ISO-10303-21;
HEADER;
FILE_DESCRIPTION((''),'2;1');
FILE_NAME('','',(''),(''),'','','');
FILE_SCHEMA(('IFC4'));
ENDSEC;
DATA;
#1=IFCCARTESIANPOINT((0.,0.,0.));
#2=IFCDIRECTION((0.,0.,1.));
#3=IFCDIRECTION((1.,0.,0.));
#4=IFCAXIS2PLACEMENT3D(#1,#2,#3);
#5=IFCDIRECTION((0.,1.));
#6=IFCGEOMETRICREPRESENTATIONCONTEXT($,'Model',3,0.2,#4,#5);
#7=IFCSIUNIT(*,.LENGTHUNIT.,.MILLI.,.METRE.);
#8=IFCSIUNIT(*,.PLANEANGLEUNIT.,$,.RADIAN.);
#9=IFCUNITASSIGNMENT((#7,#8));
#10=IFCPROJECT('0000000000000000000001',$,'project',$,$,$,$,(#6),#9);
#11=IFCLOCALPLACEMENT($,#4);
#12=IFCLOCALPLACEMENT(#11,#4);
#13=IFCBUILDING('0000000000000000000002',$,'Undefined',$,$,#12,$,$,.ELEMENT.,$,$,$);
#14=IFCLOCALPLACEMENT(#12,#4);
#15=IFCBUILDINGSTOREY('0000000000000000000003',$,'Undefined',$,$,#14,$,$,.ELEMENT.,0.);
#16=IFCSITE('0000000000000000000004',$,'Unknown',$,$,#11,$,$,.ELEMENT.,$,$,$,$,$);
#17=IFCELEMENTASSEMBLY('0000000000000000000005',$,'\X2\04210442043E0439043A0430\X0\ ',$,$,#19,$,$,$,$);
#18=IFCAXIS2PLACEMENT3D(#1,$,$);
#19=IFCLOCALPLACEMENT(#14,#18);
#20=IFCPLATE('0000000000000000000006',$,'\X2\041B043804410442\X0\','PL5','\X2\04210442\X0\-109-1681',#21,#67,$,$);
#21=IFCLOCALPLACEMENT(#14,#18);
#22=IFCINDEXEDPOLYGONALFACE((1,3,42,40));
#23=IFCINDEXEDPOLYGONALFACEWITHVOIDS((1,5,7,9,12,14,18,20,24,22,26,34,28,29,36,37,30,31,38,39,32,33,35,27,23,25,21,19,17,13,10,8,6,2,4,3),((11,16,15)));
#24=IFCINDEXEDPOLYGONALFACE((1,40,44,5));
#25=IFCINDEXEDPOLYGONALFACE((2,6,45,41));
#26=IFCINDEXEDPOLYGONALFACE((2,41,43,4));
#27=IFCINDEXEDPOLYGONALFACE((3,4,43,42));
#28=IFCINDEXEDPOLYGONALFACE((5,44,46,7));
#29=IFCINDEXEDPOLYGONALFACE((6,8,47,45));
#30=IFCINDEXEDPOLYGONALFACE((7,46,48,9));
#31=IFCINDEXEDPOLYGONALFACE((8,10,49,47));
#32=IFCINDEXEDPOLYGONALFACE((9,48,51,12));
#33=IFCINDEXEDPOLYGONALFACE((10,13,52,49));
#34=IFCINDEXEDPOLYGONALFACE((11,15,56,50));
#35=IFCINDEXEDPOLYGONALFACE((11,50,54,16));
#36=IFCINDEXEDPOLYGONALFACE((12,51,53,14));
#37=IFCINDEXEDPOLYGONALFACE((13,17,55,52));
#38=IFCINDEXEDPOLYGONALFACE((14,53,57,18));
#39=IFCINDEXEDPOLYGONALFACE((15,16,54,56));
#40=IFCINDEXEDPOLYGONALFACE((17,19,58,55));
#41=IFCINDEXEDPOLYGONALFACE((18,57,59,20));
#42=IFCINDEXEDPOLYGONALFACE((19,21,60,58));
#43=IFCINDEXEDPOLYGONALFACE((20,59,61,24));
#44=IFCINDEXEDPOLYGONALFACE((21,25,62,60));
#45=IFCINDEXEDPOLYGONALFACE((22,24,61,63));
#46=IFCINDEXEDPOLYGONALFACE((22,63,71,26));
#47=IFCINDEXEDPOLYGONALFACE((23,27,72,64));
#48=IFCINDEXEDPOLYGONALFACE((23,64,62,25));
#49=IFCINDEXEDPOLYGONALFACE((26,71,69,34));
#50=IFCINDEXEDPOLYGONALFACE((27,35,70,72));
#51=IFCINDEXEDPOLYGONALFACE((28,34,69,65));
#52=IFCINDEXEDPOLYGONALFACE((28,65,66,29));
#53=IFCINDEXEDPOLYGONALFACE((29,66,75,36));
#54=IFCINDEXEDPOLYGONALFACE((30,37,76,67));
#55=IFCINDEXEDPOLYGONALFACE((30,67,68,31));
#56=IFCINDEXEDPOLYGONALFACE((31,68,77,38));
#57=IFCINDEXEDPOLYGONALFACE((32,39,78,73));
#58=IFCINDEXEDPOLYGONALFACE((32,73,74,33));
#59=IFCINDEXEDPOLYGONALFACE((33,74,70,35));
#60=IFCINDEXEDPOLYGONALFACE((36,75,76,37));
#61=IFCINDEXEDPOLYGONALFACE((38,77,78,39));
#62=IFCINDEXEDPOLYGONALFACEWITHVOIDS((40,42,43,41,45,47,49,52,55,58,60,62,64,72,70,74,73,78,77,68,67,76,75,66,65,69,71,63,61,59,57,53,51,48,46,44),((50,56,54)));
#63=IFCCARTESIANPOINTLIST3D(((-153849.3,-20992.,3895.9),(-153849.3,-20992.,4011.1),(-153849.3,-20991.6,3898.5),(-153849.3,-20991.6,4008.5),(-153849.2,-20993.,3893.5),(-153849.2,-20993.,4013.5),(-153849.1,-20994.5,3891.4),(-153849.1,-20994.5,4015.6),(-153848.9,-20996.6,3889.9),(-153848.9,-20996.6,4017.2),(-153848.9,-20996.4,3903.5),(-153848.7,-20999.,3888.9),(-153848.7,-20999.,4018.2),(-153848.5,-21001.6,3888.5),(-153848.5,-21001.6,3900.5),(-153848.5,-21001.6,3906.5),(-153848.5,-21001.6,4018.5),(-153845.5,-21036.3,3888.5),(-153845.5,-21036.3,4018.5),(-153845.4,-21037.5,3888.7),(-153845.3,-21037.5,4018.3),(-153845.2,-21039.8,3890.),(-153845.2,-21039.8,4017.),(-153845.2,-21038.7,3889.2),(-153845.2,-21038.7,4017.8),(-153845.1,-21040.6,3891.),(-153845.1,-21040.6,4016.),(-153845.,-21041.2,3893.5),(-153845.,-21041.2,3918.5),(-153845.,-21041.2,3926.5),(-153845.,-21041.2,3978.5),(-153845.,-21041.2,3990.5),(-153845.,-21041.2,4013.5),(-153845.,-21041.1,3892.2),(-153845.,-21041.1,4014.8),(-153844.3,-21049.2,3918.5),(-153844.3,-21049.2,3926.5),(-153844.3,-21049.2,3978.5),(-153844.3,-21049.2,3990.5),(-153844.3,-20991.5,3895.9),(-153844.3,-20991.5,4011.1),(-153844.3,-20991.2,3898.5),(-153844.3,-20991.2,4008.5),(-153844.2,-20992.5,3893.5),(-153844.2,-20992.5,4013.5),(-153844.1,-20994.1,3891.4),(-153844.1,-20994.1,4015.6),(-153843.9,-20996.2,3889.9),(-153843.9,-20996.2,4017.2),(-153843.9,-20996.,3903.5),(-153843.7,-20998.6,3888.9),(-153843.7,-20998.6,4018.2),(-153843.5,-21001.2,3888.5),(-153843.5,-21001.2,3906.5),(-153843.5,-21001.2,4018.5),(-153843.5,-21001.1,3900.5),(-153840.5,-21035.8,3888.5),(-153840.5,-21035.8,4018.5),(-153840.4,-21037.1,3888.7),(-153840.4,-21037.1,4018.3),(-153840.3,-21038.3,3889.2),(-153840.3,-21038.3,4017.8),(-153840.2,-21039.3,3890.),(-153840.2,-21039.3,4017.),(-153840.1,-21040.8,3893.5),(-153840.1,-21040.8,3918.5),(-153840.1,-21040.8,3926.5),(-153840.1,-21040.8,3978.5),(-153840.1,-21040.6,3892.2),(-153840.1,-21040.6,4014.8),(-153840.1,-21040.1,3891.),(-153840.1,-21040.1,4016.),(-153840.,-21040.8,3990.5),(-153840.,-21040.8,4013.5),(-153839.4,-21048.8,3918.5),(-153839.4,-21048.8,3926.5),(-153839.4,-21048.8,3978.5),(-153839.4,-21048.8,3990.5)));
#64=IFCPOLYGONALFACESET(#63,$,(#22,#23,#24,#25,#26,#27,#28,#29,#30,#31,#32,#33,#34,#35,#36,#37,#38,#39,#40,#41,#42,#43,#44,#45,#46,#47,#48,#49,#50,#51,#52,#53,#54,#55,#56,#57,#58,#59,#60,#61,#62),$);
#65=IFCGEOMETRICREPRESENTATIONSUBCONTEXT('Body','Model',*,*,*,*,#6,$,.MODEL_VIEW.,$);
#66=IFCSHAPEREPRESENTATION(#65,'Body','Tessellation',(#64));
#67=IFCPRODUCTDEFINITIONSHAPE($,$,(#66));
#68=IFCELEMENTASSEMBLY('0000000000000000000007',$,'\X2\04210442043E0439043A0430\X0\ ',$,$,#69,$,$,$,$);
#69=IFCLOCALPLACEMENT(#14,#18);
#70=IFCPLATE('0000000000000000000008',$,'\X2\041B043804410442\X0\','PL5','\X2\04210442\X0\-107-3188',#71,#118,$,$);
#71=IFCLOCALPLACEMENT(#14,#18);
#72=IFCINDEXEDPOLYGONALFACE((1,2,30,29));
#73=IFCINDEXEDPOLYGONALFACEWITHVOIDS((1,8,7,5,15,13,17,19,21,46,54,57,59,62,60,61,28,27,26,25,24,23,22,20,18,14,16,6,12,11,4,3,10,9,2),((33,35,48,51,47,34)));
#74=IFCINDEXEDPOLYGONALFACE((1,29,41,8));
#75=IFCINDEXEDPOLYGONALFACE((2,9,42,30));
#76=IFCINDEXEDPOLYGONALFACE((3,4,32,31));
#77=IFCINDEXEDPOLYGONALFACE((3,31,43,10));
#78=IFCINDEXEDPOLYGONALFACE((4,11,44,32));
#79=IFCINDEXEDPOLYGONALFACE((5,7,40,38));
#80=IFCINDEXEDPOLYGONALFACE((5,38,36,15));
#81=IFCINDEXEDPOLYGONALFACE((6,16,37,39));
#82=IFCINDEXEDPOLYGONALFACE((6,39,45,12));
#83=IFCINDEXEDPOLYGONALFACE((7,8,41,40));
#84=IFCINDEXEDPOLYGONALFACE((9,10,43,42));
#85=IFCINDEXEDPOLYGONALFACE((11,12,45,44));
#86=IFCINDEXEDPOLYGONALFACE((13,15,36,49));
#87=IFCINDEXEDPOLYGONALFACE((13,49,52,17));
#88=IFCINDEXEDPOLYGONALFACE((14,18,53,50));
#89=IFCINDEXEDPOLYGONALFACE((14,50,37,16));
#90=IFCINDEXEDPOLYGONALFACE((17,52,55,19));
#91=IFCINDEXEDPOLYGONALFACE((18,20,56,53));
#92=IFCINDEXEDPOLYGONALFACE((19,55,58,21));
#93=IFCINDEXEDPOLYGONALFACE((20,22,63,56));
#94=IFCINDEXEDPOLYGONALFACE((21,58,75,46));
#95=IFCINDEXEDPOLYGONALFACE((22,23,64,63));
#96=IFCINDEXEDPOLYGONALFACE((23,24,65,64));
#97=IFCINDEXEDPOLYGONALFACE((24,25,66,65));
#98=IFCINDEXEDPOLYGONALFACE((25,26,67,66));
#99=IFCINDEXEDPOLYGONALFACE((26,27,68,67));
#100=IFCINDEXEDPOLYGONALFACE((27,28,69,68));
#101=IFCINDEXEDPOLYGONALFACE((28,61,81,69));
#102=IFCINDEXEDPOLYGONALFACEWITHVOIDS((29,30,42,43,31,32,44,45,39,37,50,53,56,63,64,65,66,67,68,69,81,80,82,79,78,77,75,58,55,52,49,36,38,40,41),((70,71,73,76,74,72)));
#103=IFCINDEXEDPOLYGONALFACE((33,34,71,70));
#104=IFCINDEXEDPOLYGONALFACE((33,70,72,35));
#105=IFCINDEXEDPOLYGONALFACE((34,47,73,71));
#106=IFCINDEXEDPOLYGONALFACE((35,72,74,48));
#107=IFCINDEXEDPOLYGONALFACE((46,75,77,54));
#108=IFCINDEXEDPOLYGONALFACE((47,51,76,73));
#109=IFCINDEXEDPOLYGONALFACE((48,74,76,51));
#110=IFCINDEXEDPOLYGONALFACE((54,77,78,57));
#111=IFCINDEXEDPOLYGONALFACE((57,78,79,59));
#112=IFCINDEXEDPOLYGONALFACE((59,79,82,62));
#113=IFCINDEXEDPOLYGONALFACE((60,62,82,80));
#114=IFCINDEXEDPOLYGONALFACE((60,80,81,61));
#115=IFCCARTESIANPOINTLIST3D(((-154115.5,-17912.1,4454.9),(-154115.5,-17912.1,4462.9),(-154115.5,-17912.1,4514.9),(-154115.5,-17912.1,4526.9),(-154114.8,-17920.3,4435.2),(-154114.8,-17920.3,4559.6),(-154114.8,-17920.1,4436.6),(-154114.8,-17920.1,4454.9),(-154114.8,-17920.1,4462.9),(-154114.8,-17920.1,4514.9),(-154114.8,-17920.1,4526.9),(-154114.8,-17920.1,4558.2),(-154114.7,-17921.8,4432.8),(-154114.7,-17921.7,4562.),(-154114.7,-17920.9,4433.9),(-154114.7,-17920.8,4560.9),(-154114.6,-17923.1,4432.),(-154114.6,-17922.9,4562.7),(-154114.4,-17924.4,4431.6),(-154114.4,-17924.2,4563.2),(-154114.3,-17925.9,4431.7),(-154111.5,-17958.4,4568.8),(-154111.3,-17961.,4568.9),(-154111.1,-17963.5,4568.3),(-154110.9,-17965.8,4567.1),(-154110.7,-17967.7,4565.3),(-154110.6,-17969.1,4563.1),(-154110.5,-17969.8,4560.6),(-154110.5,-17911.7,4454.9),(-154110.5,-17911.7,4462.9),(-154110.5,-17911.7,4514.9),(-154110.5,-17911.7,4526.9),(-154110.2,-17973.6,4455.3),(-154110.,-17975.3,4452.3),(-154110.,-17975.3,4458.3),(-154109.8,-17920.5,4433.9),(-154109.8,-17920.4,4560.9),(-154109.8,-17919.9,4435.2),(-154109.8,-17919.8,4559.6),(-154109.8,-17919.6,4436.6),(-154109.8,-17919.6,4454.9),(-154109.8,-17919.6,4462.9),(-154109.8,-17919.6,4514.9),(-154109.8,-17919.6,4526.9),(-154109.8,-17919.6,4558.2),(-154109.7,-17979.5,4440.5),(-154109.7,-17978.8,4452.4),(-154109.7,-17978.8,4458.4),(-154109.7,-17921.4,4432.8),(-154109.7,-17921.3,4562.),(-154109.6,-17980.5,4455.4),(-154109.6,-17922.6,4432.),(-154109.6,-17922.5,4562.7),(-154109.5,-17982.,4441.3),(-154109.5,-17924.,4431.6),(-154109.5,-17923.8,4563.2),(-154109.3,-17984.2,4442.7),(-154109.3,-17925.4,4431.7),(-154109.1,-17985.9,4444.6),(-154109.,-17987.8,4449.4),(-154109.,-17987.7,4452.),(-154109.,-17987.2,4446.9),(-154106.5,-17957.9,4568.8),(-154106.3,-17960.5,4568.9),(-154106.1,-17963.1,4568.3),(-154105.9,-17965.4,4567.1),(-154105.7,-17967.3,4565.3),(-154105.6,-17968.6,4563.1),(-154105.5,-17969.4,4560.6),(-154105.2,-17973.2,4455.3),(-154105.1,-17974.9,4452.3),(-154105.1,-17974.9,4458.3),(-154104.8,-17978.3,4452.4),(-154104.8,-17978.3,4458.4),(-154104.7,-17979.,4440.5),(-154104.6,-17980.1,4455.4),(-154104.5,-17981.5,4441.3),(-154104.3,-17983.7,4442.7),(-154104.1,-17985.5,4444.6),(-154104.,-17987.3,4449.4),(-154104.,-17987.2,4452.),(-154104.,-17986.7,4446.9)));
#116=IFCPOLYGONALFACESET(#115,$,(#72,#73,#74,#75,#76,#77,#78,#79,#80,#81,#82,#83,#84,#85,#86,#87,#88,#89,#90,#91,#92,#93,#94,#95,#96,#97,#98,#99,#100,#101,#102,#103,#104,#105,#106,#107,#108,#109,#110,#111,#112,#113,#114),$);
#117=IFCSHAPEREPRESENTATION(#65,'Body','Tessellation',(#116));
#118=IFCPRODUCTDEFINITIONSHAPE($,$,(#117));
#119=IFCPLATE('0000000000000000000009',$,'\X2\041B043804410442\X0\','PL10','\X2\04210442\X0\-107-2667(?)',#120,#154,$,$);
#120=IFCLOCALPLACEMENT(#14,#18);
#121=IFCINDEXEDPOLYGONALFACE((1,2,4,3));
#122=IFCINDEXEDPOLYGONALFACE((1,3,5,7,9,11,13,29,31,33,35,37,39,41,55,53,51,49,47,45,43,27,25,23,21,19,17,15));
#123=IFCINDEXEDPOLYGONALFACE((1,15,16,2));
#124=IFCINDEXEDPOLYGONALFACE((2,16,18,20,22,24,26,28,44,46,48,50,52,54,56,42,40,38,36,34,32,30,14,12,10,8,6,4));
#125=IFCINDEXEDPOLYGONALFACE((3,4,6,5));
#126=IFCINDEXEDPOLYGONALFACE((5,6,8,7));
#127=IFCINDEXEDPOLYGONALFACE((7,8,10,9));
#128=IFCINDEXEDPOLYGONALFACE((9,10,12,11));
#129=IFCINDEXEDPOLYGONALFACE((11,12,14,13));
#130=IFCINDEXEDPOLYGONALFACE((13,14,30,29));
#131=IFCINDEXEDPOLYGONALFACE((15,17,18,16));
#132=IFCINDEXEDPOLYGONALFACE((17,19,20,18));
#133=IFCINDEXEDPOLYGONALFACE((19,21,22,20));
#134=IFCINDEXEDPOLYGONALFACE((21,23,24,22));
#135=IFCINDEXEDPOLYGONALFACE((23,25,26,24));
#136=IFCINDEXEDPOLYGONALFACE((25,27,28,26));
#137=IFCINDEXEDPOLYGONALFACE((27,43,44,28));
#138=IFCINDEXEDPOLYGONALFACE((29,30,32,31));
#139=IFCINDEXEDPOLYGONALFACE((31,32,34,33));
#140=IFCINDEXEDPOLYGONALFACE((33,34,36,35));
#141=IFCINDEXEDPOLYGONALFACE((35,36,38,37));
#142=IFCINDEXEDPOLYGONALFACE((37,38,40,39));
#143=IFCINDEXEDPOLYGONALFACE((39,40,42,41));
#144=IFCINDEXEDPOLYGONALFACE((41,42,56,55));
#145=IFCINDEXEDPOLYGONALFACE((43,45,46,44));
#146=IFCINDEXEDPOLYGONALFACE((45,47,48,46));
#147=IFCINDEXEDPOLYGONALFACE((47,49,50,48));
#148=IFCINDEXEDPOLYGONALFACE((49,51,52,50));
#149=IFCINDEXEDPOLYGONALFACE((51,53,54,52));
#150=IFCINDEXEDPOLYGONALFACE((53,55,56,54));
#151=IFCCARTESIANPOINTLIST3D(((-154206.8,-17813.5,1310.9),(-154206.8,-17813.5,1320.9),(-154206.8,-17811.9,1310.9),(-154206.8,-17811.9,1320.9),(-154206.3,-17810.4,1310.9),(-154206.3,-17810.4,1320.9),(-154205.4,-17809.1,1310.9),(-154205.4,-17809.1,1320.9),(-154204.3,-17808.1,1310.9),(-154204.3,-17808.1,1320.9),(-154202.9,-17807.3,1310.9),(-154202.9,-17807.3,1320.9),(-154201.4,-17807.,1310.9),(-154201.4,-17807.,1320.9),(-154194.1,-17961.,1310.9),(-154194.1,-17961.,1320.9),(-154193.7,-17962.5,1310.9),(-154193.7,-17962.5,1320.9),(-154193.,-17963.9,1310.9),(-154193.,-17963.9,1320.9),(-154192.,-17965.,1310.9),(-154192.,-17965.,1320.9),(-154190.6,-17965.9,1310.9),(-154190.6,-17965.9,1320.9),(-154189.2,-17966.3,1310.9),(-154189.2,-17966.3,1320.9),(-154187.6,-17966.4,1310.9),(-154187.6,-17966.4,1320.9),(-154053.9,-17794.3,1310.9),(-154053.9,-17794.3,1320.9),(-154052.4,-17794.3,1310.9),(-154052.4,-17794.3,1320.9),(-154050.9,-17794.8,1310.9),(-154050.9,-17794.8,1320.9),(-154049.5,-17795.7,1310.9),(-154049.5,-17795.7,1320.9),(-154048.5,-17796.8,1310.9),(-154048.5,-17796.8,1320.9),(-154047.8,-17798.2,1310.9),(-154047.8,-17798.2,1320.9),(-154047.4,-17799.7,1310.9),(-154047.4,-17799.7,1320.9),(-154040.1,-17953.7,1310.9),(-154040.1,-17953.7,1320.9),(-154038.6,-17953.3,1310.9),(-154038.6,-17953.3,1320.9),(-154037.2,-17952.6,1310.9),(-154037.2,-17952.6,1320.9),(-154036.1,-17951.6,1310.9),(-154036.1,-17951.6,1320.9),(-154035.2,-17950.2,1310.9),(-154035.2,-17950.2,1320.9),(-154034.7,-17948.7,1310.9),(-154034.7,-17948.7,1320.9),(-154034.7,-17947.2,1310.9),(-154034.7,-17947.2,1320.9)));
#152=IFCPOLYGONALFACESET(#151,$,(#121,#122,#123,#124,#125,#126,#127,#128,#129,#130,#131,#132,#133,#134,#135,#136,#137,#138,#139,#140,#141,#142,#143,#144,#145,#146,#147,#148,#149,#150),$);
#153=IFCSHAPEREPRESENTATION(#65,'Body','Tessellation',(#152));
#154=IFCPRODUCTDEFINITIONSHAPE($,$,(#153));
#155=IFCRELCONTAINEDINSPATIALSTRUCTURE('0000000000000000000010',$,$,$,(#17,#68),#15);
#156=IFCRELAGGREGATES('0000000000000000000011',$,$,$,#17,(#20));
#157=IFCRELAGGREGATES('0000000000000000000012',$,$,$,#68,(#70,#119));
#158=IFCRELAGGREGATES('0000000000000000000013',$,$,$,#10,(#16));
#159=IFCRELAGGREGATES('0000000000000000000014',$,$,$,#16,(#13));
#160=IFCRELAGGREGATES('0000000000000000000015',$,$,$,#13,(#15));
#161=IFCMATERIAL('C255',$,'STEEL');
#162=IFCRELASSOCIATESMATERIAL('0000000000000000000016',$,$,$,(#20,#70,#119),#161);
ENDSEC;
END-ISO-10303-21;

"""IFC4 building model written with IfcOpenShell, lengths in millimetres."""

from ifc_helpers import new_model, si_unit, direction, frame, origin_with_axes, place, context, subcontext, project, spatial, line, arc, indexed_curve, outline, extrude, material, element, aggregate, save


model = new_model("IFC4")

# Units and contexts
model_context = context("Model", 3, precision=0.2, world=origin_with_axes(), true_north=direction((0.0, 1.0)))
body_context = subcontext(model_context, "Body", "Model", "MODEL_VIEW")
ifc_project = project(units=[si_unit("LENGTHUNIT", "METRE", prefix="MILLI"), si_unit("PLANEANGLEUNIT", "RADIAN")], contexts=[model_context])

# Site, building, storey
site_placement = place(None, origin_with_axes())
site = spatial("IfcSite", under=ifc_project, at=site_placement, Name="Unknown", CompositionType="ELEMENT")
building_placement = place(site_placement, origin_with_axes())
building = spatial("IfcBuilding", under=site, at=building_placement, Name="Undefined", CompositionType="ELEMENT")
storey_placement = place(building_placement, origin_with_axes())
storey = spatial("IfcBuildingStorey", under=building, at=storey_placement, Name="Undefined", CompositionType="ELEMENT", Elevation=0.0)

# Element assembly, plate, voiding feature
assembly_1_placement = place(storey_placement, frame((-153844.1, -21081.5, 1298.5), z_axis=(-0.086114, 0.996285, 0.0), x_axis=(0.0, 0.0, 1.0)))
assembly_1 = element("IfcElementAssembly", 1, at=assembly_1_placement, inside=storey, Name="Стойка ")
ifc_material_1 = material(Name="C255", Category="STEEL")
plate_1_placement = place(assembly_1_placement, frame((2590.0, 5.0, 90.0), z_axis=(-0.000024, 1.0, 0.0), x_axis=(1.0, 0.000024, 0.0)))
plate_1 = element("IfcPlate", 2, at=plate_1_placement, material=ifc_material_1, Name="Лист", Description="PL5", ObjectType="Ст-109-1681", context=body_context, shape_type="SolidModel", body=[
    extrude(outline(indexed_curve([(0.0, 10.0), (2.9, 2.9), (10.0, 0.0), (120.0, 0.0), (127.1, 2.9), (130.0, 10.0), (130.0, 44.8), (128.5, 48.3), (125.0, 49.8), (102.0, 49.8), (102.0, 57.8), (90.0, 57.8), (90.0, 49.8), (38.0, 49.8), (38.0, 57.8), (30.0, 57.8), (30.0, 49.8), (5.0, 49.8), (1.5, 48.3), (0.0, 44.8)], segments=[arc(1, 2, 3), line(3, 4), arc(4, 5, 6), line(6, 7), arc(7, 8, 9), line(9, 10, 11, 12, 13, 14, 15, 16, 17, 18), arc(18, 19, 20), line(20, 1)])), frame((0.0, 0.0, 2.5), z_axis=(0.0, 0.0, 1.0), x_axis=(1.0, 0.0, 0.0)), (0.0, 0.0, -1.0), 5.0),
])
voiding_feature_1_placement = place(plate_1_placement, frame((15.0, 10.0, 10.0), z_axis=(0.003022, -0.999995, 0.0), x_axis=(0.0, 0.0, -1.0)))
element("IfcVoidingFeature", 3, at=voiding_feature_1_placement, cuts=plate_1, Name="Балка", ObjectType="(?)", PredefinedType="HOLE", context=body_context, shape_type="SolidModel", body=[
    extrude(outline(indexed_curve([(0.0, -3.0), (5.2, 0.0), (0.0, 3.0)], segments=[line(1, 2, 3, 1)])), frame((0.0, 0.0, 0.0), z_axis=(-1.0, 0.0, 0.0), x_axis=(0.0, 0.0, 1.0)), (0.0, 0.0, -1.0), 20.0),
])

# Element assembly, plates, voiding feature
assembly_2_placement = place(storey_placement, frame((-154120.8, -17880.2, 4823.9), z_axis=(0.086114, -0.996285, 0.0), x_axis=(0.0, 0.0, -1.0)))
assembly_2 = element("IfcElementAssembly", 4, at=assembly_2_placement, inside=storey, Name="Стойка ")
plate_2_placement = place(assembly_2_placement, frame((381.7, 5.0, 109.7), z_axis=(-0.000024, -1.0, 0.0), x_axis=(-0.986646, 0.000024, -0.162881)))
plate_2 = element("IfcPlate", 5, at=plate_2_placement, material=ifc_material_1, Name="Лист", Description="PL5", ObjectType="Ст-107-3188", context=body_context, shape_type="SolidModel", body=[
    extrude(outline(indexed_curve([(0.0, 10.0), (2.9, 2.9), (10.0, 0.0), (120.0, 0.0), (127.1, 2.9), (130.0, 10.0), (130.0, 44.7), (128.8, 48.0), (125.8, 49.6), (94.9, 54.8), (96.2, 62.6), (84.4, 64.6), (83.1, 56.7), (31.7, 65.2), (33.1, 73.1), (25.2, 74.4), (23.9, 66.5), (5.8, 69.5), (1.8, 68.3), (0.0, 64.5)], segments=[arc(1, 2, 3), line(3, 4), arc(4, 5, 6), line(6, 7), arc(7, 8, 9), line(9, 10, 11, 12, 13, 14, 15, 16, 17, 18), arc(18, 19, 20), line(20, 1)])), frame((0.0, 0.0, 2.5), z_axis=(0.0, 0.0, 1.0), x_axis=(1.0, 0.0, 0.0)), (0.0, 0.0, -1.0), 5.0),
])
voiding_feature_2_placement = place(plate_2_placement, frame((15.0, 10.0, 10.0), z_axis=(-0.159897, -0.987134, 0.0), x_axis=(0.0, 0.0, -1.0)))
element("IfcVoidingFeature", 6, at=voiding_feature_2_placement, cuts=plate_2, Name="Балка", ObjectType="(?)", PredefinedType="HOLE", context=body_context, shape_type="SolidModel", body=[
    extrude(outline(indexed_curve([(1.7, -3.0), (3.5, 0.0), (1.7, 3.0), (-1.7, 3.0), (-3.5, 0.0), (-1.7, -3.0)], segments=[line(1, 2, 3, 4, 5, 6, 1)])), frame((0.0, 0.0, 0.0), z_axis=(-1.0, 0.0, 0.0), x_axis=(0.0, 0.0, 1.0)), (0.0, 0.0, -1.0), 20.0),
])
plate_3_placement = place(assembly_2_placement, frame((3508.0, 80.0, 80.1), z_axis=(-1.0, 0.0, 0.0), x_axis=(0.0, 0.0, -1.0)))
plate_3 = element("IfcPlate", 7, at=plate_3_placement, material=ifc_material_1, Name="Лист", Description="PL10", ObjectType="Ст-107-2667(?)", context=body_context, shape_type="SolidModel", body=[
    extrude(outline(indexed_curve([(0.0, 6.0), (1.8, 1.8), (6.0, 0.0), (154.0, 0.0), (158.2, 1.8), (160.0, 6.0), (160.0, 154.0), (158.2, 158.2), (154.0, 160.0), (6.0, 160.0), (1.8, 158.2), (0.0, 154.0)], segments=[arc(1, 2, 3), line(3, 4), arc(4, 5, 6), line(6, 7), arc(7, 8, 9), line(9, 10), arc(10, 11, 12), line(12, 1)])), frame((0.0, 0.0, 5.0), z_axis=(0.0, 0.0, 1.0), x_axis=(1.0, 0.0, 0.0)), (0.0, 0.0, -1.0), 10.0),
])

aggregate(assembly_1, [plate_1])
aggregate(assembly_2, [plate_2, plate_3])

save(model, "model.ifc")
